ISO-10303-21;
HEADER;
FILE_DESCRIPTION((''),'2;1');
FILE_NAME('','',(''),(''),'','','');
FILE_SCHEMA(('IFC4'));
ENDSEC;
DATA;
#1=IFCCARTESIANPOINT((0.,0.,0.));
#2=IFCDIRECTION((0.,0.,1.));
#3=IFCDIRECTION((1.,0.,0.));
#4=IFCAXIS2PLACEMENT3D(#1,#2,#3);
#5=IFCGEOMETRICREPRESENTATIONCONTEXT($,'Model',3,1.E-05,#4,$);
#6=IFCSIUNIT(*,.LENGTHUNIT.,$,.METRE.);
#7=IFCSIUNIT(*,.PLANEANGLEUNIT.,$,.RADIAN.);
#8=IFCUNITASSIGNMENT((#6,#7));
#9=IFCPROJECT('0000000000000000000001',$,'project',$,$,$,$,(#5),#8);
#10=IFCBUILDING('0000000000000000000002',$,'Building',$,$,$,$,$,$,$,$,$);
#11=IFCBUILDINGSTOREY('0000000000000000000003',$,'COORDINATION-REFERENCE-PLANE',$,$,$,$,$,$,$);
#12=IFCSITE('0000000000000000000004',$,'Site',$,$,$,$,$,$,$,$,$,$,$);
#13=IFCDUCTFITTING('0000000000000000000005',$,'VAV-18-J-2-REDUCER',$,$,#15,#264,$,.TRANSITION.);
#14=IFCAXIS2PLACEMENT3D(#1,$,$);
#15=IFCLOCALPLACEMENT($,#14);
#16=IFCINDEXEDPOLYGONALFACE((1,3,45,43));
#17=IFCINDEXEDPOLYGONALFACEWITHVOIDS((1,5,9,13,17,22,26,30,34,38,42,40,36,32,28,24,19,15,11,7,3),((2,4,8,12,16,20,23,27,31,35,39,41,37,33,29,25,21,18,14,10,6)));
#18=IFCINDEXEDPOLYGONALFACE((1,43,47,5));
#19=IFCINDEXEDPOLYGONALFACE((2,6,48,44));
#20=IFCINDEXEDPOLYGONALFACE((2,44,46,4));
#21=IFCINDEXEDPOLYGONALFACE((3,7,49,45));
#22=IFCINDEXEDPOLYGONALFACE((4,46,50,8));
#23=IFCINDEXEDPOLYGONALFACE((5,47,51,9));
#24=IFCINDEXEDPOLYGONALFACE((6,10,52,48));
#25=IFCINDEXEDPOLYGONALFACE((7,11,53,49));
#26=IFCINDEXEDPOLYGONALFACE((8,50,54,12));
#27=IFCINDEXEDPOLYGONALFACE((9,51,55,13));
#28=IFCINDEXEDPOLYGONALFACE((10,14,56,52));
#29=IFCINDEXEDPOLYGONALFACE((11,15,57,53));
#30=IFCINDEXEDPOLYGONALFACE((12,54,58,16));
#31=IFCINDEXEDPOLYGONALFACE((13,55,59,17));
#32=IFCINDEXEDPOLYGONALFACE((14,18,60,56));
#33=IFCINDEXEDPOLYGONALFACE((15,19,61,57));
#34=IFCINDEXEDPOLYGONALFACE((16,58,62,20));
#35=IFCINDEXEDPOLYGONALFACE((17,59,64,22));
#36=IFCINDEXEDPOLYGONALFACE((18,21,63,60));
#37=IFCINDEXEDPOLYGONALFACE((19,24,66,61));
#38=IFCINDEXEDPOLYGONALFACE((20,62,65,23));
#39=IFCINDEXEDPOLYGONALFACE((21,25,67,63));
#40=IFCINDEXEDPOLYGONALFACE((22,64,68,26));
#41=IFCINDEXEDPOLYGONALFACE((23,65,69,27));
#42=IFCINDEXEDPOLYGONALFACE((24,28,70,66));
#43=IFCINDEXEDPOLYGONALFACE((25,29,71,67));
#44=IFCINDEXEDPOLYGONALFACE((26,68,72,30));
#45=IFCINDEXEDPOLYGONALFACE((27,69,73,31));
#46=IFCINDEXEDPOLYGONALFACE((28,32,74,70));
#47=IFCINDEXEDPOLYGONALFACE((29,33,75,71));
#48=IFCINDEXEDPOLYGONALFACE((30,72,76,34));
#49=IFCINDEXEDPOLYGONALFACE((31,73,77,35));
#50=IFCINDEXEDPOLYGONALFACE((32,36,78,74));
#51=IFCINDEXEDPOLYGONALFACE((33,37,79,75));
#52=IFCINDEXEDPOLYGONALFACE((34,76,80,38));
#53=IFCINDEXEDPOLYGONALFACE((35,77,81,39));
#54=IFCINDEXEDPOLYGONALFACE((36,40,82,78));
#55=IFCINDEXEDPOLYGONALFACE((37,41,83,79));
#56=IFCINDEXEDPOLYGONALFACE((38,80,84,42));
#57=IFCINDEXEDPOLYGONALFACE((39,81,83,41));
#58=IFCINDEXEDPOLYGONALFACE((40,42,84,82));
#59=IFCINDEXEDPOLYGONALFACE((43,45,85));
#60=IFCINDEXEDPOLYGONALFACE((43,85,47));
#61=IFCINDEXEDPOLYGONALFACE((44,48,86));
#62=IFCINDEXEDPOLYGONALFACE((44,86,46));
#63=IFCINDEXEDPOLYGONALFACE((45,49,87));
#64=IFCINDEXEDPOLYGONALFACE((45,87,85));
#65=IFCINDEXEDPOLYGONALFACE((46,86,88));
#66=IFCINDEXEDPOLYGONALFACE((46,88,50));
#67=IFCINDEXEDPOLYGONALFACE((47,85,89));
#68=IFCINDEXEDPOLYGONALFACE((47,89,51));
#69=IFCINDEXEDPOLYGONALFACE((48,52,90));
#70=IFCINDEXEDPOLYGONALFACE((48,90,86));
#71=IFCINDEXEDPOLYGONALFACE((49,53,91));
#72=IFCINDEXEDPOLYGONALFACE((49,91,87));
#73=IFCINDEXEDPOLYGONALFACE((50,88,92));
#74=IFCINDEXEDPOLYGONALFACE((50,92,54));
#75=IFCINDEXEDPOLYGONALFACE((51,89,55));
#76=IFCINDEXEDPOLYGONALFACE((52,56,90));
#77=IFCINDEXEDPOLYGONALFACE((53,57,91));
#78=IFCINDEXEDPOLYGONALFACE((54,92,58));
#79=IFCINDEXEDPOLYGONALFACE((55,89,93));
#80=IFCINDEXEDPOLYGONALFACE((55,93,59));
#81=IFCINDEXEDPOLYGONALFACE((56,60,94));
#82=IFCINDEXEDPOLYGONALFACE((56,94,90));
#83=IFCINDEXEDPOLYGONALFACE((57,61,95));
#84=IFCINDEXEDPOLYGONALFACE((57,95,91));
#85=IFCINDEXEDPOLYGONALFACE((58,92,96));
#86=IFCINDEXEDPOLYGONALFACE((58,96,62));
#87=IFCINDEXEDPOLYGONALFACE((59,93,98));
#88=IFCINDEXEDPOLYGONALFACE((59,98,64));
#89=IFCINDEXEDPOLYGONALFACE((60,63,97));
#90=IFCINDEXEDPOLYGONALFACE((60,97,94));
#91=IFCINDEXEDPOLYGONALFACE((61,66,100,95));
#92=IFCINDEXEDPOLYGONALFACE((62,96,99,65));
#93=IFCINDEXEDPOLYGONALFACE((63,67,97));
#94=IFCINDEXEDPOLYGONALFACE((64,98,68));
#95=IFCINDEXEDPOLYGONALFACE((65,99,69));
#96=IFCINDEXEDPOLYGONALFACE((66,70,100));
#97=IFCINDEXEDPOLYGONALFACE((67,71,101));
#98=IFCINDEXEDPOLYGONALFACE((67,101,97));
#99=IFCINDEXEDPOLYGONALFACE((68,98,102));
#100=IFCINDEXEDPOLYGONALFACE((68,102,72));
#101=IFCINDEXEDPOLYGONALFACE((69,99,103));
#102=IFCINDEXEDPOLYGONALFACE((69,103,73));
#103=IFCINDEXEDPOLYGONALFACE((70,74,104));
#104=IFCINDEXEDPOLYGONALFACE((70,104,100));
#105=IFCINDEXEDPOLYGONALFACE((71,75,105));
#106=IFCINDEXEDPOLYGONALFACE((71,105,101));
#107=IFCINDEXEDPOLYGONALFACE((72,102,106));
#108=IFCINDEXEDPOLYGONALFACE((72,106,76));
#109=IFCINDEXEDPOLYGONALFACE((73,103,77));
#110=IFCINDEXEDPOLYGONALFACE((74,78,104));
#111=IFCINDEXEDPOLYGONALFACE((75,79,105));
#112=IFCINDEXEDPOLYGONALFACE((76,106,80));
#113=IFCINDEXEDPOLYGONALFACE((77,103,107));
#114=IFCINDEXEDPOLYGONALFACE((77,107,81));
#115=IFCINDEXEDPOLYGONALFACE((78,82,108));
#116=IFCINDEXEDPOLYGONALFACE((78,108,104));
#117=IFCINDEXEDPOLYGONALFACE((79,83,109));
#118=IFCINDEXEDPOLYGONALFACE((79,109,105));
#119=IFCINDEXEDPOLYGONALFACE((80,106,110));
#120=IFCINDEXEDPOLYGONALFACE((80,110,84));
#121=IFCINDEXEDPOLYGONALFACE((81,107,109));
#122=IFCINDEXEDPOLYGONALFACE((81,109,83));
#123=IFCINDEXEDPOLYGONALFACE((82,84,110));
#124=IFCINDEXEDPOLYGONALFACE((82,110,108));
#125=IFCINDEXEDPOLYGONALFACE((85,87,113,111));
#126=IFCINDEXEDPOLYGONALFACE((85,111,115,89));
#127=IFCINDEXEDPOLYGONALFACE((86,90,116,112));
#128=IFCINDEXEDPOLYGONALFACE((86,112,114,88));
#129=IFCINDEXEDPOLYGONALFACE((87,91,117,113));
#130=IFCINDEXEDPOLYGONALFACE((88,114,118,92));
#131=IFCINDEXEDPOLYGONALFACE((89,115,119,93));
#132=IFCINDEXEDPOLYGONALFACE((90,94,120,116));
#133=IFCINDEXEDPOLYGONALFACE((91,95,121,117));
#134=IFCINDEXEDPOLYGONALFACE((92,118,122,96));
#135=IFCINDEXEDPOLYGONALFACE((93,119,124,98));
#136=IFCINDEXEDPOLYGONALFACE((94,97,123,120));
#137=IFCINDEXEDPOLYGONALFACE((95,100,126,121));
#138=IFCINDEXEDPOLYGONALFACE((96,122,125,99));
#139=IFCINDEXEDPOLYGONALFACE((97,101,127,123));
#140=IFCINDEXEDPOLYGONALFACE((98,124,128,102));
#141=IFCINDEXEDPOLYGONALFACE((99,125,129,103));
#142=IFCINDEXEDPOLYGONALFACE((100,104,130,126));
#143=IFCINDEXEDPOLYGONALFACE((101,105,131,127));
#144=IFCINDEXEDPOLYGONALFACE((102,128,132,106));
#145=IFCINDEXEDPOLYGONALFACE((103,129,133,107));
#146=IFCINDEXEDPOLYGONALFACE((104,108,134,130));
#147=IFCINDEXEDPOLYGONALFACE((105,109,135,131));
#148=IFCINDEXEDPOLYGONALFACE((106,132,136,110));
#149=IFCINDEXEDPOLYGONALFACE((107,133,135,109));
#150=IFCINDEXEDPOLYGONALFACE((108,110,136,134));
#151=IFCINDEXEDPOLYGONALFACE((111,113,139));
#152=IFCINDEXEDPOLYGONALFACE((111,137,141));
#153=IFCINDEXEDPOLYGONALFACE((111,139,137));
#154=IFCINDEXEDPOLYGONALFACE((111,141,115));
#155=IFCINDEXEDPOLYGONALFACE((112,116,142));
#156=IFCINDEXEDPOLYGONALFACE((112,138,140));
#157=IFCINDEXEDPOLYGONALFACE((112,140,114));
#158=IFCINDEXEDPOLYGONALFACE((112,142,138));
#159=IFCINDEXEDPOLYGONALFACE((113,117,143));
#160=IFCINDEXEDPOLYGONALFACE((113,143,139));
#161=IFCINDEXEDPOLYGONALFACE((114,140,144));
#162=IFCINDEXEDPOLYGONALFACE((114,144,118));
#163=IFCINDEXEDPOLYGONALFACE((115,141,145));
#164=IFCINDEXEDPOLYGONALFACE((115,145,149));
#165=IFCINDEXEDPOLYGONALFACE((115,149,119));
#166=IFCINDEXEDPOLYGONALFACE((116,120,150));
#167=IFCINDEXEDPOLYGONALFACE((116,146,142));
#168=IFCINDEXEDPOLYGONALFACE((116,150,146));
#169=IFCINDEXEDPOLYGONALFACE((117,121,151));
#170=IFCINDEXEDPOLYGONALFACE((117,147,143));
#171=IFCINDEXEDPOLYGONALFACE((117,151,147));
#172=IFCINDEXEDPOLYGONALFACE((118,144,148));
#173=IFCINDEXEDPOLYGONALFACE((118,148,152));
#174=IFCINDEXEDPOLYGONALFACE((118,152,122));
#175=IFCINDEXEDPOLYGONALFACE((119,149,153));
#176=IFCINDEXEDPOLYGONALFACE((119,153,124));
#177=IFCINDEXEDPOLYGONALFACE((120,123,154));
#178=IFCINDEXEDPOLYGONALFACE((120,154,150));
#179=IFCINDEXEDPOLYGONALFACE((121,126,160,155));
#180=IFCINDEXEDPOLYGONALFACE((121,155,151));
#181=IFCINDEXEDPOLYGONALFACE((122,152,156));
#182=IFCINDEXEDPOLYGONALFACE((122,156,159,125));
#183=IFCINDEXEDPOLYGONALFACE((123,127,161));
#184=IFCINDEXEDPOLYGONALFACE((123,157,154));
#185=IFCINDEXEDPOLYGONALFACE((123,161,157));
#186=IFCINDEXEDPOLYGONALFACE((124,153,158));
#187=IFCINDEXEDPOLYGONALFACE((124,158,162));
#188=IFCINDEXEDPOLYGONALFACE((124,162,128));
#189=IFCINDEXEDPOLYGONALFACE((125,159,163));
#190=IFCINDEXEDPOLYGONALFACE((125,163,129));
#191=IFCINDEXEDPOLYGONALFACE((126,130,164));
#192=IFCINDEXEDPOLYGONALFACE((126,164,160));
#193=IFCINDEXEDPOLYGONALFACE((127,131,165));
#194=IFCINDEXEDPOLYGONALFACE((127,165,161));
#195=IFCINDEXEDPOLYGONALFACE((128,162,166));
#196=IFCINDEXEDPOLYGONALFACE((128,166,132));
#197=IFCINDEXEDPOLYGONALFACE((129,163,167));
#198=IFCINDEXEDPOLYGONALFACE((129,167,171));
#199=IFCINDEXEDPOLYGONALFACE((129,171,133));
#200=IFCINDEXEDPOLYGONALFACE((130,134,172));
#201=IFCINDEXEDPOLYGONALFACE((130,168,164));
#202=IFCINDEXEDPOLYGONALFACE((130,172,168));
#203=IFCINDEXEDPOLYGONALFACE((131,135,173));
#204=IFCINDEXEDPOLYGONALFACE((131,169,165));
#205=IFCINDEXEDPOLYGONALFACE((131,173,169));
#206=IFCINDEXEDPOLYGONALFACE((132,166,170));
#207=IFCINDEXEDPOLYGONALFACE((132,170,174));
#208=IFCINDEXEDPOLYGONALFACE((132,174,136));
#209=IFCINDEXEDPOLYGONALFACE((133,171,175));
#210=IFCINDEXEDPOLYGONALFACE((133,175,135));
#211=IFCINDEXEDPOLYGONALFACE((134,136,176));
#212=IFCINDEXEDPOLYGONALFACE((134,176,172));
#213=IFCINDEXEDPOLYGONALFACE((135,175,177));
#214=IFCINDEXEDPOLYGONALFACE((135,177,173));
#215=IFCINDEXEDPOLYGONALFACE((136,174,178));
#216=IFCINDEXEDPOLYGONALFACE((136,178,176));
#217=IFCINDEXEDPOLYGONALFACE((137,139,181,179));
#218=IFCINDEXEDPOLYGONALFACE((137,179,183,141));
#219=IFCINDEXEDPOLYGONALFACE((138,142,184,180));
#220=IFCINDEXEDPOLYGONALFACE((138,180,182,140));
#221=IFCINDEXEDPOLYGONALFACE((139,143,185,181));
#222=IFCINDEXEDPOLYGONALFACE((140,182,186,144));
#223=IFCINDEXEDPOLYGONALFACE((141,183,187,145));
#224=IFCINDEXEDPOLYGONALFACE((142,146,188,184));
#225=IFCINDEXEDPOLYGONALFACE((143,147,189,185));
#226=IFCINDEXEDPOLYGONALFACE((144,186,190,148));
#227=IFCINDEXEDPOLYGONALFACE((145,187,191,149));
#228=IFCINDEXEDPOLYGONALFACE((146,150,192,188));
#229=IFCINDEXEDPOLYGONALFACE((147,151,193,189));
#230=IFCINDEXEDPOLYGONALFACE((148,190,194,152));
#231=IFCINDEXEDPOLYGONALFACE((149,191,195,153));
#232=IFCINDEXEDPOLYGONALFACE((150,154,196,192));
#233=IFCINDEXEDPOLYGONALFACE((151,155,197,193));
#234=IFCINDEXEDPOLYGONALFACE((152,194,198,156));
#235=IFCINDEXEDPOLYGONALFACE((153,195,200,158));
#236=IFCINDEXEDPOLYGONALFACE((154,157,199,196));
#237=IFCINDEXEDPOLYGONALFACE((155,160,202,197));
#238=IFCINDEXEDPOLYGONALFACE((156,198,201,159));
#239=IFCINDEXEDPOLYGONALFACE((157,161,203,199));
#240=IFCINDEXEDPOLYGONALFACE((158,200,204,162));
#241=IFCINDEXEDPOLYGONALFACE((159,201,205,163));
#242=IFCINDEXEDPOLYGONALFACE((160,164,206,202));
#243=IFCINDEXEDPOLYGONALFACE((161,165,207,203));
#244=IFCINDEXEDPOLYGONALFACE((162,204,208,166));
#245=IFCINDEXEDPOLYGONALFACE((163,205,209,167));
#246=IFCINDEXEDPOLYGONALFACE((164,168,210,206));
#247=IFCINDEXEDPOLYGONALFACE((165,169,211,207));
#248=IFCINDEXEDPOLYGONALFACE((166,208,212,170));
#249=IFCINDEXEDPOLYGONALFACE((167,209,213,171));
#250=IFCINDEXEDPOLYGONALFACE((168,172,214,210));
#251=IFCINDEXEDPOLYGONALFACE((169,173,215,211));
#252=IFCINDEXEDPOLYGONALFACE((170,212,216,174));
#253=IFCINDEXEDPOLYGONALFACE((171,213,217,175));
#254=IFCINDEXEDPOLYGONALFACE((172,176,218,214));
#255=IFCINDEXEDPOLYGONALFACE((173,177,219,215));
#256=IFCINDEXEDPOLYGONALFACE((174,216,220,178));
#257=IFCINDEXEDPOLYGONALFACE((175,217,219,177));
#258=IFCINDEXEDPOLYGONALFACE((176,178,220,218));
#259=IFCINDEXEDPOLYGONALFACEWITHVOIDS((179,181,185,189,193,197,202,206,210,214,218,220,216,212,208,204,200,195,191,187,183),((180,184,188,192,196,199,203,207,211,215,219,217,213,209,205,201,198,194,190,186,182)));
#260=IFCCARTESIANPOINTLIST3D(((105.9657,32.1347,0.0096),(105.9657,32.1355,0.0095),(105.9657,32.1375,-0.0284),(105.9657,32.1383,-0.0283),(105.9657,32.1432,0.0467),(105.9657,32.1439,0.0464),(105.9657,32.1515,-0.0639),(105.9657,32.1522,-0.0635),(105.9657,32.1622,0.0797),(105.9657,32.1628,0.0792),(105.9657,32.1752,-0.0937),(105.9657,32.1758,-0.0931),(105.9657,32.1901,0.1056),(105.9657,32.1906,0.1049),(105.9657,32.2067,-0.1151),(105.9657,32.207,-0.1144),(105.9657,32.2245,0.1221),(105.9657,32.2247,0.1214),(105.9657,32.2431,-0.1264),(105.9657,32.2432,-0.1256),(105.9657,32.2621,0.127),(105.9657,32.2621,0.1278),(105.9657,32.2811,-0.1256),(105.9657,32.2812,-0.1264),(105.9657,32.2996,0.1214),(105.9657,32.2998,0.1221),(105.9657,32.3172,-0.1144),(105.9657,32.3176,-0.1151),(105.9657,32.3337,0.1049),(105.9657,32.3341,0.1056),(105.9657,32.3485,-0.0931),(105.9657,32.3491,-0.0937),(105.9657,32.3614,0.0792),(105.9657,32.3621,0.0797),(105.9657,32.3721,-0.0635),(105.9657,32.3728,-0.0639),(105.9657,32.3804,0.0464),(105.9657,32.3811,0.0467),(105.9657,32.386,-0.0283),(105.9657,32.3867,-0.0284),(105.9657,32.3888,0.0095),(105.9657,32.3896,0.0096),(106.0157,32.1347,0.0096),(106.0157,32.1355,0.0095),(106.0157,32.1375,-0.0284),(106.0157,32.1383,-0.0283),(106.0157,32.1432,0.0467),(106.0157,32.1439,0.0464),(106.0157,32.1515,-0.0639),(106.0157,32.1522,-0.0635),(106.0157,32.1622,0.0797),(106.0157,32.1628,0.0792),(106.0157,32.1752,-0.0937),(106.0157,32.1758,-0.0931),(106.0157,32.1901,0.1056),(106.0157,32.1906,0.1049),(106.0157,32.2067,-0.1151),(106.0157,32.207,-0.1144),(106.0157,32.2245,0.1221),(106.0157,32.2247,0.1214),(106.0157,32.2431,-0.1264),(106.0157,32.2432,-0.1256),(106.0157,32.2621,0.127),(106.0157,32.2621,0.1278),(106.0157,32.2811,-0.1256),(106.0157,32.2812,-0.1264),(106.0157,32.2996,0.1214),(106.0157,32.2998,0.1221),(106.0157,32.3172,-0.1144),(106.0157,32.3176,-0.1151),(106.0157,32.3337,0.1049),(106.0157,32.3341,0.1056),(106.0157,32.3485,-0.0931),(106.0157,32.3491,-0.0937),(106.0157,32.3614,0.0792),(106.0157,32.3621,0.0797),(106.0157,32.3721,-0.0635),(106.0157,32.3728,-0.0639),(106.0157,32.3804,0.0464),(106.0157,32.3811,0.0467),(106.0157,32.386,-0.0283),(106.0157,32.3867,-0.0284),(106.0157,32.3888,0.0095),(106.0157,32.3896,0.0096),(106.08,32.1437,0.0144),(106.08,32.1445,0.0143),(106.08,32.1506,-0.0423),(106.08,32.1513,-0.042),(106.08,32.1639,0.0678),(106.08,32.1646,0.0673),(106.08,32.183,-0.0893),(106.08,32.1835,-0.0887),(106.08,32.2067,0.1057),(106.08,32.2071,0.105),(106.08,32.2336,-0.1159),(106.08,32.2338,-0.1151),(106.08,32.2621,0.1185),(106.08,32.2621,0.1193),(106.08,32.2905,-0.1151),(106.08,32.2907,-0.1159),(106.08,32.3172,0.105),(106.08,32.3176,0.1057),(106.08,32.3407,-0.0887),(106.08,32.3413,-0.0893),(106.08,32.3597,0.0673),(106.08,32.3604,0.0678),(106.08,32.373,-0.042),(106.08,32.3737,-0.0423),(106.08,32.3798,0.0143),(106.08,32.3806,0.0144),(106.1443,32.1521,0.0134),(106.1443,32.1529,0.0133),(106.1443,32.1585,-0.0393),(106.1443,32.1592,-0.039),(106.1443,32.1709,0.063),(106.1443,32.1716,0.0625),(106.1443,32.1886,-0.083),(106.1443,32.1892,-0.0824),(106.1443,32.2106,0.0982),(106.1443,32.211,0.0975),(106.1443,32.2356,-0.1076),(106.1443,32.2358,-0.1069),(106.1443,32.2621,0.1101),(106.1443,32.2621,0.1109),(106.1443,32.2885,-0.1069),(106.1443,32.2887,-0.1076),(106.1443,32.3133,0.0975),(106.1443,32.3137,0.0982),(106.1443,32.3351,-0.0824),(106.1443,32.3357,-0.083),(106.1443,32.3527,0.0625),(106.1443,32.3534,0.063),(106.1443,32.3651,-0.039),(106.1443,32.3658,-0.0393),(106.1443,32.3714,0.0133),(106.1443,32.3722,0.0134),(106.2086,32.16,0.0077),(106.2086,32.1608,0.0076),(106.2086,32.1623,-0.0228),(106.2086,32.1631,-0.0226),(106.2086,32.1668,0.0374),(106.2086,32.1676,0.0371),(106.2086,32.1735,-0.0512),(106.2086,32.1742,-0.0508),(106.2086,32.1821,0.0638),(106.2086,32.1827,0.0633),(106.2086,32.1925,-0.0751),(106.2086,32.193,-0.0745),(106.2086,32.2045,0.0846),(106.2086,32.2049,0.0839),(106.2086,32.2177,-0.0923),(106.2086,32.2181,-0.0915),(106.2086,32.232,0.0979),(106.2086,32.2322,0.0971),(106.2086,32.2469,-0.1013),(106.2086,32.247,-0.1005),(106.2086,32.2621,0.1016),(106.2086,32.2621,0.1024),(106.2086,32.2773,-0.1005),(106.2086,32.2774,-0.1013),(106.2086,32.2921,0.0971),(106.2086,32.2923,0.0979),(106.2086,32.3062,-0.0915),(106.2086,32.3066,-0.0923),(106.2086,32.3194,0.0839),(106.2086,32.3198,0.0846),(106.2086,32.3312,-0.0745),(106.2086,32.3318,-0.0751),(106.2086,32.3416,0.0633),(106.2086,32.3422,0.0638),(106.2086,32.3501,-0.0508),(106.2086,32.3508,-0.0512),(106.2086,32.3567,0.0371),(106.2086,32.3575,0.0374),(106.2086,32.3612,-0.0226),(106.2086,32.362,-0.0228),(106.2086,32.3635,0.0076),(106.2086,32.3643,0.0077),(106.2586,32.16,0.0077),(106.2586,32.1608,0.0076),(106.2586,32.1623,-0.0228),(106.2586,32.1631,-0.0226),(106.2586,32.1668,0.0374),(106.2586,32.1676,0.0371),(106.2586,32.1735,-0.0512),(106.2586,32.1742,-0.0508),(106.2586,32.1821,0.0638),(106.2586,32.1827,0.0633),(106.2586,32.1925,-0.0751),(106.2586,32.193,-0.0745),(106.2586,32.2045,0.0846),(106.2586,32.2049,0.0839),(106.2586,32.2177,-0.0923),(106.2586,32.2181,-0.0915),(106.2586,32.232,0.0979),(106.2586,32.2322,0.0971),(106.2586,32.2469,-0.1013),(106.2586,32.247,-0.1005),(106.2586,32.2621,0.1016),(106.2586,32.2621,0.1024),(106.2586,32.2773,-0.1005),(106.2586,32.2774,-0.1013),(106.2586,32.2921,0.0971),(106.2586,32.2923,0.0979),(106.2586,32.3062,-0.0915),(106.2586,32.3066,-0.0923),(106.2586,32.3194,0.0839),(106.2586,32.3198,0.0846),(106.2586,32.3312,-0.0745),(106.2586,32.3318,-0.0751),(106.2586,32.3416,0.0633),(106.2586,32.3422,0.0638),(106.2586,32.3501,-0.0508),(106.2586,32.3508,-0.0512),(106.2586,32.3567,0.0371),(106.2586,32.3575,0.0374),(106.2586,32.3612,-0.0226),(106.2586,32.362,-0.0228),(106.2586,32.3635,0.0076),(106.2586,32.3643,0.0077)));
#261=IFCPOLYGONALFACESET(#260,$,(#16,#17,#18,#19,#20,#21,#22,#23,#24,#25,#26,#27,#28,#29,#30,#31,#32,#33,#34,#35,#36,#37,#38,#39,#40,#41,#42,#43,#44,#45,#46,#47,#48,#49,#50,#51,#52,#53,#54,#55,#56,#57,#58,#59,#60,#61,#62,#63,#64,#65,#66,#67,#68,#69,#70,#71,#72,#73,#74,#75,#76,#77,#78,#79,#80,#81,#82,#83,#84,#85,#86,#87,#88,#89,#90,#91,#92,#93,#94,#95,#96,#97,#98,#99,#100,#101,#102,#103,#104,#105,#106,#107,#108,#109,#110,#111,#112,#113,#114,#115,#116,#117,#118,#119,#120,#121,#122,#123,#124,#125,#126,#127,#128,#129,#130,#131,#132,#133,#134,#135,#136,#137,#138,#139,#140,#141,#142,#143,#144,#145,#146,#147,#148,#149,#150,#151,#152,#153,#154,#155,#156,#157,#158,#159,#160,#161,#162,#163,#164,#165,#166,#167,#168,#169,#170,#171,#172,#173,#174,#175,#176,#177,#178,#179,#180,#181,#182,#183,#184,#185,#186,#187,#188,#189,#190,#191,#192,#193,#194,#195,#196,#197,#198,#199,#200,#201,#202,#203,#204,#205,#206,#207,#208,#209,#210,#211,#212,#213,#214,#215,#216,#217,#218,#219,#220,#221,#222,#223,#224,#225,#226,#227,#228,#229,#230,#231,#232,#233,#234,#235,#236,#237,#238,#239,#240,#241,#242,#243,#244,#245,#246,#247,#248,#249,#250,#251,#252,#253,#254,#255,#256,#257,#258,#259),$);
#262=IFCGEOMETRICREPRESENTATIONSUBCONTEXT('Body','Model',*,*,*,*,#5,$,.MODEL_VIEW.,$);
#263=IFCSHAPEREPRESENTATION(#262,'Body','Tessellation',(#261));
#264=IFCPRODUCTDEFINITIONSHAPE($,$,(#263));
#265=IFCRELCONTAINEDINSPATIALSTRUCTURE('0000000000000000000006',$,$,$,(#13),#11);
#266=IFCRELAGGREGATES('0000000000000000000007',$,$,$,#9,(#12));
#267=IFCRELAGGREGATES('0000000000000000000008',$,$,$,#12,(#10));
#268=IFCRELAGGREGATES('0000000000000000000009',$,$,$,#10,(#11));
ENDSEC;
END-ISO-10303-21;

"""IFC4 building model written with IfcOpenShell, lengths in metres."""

from ifc_helpers import new_model, entity, si_unit, frame, origin_with_axes, place, context, subcontext, project, spatial, element, save


model = new_model("IFC4")

# Units and contexts
model_context = context("Model", 3, precision=1e-05, world=origin_with_axes())
body_context_1 = subcontext(model_context, "Body", "Model", "MODEL_VIEW")
ifc_project = project(units=[si_unit("LENGTHUNIT", "METRE"), si_unit("PLANEANGLEUNIT", "RADIAN")], contexts=[model_context])

# Site, building, storey
site = spatial("IfcSite", under=ifc_project, Name="Site")
building = spatial("IfcBuilding", under=site, Name="Building")
storey = spatial("IfcBuildingStorey", under=building, Name="COORDINATION-REFERENCE-PLANE")

# Duct fitting
for number, where, z_axis, x_axis, name in (
    (1, (105.9657, 32.2621, 0.0), (0.0, 1.0, 0.0), (0.0, 0.0, 1.0), "VAV-18-J-2-REDUCER"),
):
    element("IfcDuctFitting", number, at=place(None, frame(where, z_axis=z_axis, x_axis=x_axis)), inside=storey, Name=name, PredefinedType="TRANSITION", context=body_context_1, shape_type="SweptSolid", body=[
        entity("IfcRevolvedAreaSolid", entity("IfcArbitraryClosedProfileDef", "AREA", None, entity("IfcPolyline", [entity("IfcCartesianPoint", [0.1278, 0.0]), entity("IfcCartesianPoint", [0.1278, 0.05]), entity("IfcCartesianPoint", [0.1024, 0.2429]), entity("IfcCartesianPoint", [0.1024, 0.2929]), entity("IfcCartesianPoint", [0.1016, 0.2929]), entity("IfcCartesianPoint", [0.1016, 0.2429]), entity("IfcCartesianPoint", [0.127, 0.05]), entity("IfcCartesianPoint", [0.127, 0.0]), entity("IfcCartesianPoint", [0.1278, 0.0])])), entity("IfcAxis2Placement3D", entity("IfcCartesianPoint", [0.0, 0.0, 0.0])), entity("IfcAxis1Placement", entity("IfcCartesianPoint", [0.0, 0.0, 0.0]), entity("IfcDirection", [0.0, 1.0, 0.0])), 6.283185),
    ])

save(model, "model.ifc")
